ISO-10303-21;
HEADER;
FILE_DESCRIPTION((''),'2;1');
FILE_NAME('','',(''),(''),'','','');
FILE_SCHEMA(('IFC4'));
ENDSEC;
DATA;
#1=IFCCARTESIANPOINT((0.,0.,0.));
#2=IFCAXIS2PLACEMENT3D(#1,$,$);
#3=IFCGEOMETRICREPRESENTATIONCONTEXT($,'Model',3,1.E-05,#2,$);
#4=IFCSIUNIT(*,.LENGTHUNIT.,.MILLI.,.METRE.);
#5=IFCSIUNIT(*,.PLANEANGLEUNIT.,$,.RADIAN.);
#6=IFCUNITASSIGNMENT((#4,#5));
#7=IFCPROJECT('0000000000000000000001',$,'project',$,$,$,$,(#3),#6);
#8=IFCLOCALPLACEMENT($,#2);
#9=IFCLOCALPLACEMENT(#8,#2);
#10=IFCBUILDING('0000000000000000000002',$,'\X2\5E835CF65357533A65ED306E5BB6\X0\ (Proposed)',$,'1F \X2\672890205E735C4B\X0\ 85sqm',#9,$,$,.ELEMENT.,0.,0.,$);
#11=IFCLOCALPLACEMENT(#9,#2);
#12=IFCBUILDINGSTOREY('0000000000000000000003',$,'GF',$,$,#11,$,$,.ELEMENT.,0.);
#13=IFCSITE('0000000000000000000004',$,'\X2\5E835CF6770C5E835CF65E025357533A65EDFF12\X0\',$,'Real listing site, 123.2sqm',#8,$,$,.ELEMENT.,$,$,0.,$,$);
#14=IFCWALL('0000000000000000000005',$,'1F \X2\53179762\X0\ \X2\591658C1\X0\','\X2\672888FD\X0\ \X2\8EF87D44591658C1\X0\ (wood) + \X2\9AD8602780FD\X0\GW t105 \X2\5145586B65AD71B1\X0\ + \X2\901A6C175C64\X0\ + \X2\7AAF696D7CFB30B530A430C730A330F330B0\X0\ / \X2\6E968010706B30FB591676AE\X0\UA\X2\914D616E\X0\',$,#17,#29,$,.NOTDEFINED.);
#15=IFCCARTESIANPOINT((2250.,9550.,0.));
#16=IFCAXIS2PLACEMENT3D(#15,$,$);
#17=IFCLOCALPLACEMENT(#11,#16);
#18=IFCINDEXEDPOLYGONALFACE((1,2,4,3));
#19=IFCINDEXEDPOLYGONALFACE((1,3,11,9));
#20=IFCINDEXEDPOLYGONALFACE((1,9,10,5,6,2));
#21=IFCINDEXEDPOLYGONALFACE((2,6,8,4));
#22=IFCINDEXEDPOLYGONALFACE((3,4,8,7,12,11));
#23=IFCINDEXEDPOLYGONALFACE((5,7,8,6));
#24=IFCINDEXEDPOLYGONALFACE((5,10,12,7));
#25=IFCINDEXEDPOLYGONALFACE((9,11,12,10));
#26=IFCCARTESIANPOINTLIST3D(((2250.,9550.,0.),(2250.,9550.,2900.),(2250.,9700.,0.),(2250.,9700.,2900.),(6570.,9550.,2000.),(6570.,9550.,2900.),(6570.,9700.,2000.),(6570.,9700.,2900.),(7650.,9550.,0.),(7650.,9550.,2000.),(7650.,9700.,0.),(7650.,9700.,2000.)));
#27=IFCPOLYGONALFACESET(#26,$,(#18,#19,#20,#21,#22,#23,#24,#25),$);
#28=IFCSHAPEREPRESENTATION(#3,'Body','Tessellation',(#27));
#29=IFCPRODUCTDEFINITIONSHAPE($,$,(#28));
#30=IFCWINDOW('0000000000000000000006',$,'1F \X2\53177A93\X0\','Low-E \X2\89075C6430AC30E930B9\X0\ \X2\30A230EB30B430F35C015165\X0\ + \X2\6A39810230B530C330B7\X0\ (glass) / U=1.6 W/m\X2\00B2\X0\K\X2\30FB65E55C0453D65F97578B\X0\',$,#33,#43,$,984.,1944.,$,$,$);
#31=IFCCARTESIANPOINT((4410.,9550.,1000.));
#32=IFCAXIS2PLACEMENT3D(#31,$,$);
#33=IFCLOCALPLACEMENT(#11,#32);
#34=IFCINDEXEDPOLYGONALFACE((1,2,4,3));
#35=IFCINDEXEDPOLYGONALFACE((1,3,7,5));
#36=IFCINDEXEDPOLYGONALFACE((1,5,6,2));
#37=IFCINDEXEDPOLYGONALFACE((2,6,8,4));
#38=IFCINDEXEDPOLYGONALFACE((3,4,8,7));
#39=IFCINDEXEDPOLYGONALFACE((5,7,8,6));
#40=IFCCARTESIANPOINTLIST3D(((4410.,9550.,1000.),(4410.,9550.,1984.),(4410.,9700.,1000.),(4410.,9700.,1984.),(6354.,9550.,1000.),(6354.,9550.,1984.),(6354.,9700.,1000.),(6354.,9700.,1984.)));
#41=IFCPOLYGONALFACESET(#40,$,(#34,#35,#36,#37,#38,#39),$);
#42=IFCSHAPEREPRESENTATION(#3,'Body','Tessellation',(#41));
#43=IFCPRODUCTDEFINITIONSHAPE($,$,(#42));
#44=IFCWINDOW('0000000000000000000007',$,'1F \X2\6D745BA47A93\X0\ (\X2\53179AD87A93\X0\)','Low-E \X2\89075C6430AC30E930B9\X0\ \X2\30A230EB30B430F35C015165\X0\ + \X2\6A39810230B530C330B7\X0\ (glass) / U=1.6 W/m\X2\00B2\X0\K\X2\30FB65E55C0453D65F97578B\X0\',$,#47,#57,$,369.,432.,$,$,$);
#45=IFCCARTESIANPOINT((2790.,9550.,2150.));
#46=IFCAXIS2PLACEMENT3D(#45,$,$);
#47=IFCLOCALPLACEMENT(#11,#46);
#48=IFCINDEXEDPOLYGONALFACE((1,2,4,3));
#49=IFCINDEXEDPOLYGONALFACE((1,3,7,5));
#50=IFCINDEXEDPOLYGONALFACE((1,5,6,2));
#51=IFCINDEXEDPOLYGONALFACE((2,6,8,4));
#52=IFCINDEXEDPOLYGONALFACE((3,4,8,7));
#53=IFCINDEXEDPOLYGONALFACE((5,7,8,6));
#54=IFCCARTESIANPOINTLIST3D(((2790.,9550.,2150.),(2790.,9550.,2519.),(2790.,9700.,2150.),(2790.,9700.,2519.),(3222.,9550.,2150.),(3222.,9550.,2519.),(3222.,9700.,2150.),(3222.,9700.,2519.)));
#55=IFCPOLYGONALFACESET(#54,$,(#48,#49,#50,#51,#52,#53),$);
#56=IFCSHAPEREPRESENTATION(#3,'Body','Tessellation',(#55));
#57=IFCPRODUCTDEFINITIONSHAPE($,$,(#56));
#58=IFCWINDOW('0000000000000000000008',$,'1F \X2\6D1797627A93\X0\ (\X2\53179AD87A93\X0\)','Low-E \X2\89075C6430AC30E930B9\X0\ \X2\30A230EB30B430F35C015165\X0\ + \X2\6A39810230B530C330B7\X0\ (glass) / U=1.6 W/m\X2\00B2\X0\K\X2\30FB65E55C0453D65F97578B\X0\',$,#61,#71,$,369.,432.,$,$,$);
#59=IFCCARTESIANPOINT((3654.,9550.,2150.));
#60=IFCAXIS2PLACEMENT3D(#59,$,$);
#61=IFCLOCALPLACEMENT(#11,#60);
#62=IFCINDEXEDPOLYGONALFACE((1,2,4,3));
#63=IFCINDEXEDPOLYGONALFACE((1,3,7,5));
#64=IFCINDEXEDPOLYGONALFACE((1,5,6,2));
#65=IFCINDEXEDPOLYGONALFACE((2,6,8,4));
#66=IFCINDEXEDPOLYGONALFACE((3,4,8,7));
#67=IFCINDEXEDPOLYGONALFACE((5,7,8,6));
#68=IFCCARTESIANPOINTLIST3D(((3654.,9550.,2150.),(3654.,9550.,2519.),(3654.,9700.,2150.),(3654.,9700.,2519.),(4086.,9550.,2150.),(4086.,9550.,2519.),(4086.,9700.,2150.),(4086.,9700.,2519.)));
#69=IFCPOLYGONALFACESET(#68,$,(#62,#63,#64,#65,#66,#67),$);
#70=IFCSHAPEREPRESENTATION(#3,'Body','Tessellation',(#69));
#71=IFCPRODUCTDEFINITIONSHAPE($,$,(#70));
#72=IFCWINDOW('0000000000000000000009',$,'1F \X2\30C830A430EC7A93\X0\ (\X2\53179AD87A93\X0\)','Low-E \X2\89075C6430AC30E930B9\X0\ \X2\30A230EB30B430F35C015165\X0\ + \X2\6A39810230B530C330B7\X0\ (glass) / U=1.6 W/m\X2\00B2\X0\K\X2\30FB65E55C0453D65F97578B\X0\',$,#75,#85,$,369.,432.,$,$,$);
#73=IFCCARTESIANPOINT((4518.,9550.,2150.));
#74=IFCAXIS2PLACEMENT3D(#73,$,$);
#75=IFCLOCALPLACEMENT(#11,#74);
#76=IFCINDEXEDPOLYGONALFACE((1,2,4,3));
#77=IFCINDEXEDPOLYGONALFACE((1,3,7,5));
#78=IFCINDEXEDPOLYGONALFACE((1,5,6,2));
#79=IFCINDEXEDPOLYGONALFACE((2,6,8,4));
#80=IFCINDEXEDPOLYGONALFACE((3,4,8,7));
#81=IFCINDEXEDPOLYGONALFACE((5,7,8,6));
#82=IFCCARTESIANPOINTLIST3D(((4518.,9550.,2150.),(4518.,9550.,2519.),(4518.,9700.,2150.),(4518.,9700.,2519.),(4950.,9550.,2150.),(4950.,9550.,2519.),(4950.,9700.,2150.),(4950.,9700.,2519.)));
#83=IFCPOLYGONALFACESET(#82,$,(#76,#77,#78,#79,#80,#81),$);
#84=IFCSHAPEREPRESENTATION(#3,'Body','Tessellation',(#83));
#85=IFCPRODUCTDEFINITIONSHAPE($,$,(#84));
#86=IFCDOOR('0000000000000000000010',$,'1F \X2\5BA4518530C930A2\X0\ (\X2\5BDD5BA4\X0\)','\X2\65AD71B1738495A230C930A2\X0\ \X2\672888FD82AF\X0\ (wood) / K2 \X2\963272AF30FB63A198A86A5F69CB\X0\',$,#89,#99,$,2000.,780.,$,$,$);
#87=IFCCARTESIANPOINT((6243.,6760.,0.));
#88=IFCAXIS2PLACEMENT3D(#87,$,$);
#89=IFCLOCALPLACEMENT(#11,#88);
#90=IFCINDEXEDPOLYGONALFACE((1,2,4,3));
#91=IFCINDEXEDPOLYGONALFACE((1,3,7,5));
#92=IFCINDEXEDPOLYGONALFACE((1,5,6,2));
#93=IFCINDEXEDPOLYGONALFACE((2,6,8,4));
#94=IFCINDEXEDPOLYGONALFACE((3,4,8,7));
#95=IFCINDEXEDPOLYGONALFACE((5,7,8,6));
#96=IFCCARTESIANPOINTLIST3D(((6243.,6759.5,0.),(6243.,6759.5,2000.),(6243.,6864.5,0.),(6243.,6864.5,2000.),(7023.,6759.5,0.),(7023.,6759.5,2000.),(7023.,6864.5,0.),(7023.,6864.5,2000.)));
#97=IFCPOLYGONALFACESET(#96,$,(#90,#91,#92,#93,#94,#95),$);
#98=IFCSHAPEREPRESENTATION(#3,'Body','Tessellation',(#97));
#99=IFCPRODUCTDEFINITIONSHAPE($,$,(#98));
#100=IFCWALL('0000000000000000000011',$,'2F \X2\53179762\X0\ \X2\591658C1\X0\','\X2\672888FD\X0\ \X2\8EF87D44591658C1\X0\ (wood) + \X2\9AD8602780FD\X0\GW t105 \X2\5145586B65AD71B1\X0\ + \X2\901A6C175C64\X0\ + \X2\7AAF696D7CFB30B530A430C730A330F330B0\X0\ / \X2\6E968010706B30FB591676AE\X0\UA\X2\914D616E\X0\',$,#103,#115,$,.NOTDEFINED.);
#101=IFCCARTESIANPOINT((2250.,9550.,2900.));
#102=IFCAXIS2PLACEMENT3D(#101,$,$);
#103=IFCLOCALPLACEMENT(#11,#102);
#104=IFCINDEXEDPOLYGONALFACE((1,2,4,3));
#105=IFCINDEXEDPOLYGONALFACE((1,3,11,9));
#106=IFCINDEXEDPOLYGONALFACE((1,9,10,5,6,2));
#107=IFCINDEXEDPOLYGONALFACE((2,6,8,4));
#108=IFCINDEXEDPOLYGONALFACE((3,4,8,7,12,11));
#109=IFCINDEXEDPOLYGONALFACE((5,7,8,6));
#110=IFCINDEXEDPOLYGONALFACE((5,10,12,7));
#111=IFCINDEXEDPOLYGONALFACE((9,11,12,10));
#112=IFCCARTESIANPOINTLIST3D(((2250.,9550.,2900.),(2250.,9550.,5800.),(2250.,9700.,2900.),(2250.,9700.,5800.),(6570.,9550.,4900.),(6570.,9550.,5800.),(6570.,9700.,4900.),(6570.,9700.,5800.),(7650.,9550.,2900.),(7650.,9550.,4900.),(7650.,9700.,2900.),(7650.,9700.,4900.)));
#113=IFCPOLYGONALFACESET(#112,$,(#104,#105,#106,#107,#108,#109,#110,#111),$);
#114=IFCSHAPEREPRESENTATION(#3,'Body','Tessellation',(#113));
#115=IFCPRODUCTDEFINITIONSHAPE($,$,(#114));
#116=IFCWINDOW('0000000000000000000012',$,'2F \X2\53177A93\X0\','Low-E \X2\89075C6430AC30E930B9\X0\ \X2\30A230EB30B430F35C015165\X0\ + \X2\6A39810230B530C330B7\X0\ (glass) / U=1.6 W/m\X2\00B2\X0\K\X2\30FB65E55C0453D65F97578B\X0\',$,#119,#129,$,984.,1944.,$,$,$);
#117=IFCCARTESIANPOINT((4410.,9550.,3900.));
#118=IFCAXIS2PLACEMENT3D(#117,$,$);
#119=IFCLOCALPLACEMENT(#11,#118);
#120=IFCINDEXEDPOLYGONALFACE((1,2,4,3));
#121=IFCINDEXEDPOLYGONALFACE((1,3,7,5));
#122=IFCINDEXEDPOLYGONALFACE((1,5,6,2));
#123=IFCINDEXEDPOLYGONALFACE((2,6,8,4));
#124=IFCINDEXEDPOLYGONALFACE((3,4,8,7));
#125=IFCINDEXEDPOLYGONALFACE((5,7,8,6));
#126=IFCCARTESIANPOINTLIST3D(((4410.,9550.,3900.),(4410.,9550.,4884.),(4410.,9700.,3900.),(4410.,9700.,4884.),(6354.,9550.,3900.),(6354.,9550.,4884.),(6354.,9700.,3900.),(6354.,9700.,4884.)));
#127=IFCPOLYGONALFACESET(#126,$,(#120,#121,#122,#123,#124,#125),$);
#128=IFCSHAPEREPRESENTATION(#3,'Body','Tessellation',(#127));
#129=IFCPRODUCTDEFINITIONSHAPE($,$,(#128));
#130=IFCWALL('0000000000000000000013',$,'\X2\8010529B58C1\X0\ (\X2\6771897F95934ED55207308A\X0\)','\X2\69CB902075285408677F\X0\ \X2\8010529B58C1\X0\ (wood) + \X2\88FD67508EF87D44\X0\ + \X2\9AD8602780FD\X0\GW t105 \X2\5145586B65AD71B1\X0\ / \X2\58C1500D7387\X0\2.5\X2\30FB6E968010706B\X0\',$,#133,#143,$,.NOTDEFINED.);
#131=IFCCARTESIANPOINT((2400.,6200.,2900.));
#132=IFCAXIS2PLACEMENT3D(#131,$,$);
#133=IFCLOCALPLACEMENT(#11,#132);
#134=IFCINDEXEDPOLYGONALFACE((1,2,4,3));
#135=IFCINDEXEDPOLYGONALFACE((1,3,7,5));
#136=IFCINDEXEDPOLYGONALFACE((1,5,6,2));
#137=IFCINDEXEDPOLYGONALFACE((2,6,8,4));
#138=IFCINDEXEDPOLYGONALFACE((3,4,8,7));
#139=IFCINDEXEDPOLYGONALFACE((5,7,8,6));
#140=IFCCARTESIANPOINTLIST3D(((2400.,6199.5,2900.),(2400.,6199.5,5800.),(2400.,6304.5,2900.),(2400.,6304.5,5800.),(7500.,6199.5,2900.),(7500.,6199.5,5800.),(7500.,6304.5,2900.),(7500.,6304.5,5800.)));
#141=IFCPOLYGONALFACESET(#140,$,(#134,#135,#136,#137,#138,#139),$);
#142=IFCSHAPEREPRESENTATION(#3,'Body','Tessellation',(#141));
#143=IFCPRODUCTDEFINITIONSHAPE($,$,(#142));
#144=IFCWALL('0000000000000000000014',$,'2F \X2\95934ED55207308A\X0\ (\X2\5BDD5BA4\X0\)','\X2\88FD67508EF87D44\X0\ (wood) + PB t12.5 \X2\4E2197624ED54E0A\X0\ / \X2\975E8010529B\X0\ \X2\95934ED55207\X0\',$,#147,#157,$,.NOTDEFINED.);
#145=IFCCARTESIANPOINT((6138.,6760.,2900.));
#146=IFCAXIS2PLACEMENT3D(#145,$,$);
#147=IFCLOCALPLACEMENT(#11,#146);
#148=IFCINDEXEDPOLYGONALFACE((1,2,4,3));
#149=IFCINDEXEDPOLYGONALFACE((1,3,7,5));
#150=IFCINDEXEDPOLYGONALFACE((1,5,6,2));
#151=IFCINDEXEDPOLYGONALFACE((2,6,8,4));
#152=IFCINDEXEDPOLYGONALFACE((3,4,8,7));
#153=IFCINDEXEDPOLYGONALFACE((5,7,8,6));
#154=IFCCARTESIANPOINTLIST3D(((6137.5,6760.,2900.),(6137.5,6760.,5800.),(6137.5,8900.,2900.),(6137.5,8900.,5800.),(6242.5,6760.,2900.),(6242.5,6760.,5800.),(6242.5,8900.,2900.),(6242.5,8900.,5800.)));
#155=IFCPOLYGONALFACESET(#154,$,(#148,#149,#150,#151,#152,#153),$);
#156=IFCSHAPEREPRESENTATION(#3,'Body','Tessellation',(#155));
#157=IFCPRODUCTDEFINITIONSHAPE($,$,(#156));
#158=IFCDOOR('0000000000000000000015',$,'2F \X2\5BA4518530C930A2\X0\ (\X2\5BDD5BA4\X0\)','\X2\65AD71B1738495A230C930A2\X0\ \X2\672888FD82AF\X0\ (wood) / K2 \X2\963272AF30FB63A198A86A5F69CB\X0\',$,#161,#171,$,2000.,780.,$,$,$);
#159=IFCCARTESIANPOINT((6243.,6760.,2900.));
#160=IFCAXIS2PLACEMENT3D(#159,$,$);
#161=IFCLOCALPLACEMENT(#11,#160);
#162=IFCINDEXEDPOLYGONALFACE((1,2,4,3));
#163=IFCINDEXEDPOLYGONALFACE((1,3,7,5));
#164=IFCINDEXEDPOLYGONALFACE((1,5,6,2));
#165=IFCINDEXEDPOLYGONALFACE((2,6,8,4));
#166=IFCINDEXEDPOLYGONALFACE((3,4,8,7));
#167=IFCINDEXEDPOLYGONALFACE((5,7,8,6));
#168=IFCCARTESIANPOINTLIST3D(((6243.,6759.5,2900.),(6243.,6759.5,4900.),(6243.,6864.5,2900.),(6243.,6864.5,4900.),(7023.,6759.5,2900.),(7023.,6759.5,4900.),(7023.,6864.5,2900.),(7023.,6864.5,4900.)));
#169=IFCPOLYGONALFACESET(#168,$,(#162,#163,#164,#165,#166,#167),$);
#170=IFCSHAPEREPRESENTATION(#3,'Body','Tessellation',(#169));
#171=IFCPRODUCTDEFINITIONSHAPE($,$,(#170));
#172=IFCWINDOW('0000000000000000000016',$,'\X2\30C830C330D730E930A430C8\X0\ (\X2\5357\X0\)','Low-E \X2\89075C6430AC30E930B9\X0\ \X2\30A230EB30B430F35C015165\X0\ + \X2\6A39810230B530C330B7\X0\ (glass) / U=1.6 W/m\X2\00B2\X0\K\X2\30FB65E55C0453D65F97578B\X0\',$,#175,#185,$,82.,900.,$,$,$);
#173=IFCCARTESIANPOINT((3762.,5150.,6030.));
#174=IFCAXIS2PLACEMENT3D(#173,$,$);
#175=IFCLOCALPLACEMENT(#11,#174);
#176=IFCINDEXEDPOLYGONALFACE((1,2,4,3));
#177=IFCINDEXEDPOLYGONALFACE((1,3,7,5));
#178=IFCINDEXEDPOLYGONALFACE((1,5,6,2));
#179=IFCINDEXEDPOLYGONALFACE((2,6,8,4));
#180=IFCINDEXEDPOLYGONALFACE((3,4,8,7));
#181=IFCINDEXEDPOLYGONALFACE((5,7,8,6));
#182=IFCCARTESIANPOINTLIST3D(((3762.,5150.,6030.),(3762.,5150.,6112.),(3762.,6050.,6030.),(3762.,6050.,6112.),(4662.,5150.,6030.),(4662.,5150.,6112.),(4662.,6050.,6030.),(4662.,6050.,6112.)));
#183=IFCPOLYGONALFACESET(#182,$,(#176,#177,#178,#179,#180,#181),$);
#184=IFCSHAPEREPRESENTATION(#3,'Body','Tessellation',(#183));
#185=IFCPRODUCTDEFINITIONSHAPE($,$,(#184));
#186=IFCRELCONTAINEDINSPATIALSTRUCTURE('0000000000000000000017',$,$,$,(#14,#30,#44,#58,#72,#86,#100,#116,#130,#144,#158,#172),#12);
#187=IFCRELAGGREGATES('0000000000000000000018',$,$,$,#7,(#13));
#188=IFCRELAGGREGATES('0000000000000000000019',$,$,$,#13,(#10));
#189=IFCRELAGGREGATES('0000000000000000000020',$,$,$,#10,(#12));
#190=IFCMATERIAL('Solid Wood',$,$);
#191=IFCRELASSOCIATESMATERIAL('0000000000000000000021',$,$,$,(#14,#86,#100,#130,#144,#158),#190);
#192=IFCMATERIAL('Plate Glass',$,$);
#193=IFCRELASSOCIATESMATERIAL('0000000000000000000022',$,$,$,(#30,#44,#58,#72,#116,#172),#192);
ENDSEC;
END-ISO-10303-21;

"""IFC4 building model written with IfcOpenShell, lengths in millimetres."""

from ifc_helpers import new_model, si_unit, frame, frame_2d, origin, place, context, project, spatial, rectangle, extrude, material, element, fill, save


model = new_model("IFC4")

# Units and contexts
model_context = context("Model", 3, precision=1e-05, world=origin())
ifc_project = project(units=[si_unit("LENGTHUNIT", "METRE", prefix="MILLI"), si_unit("PLANEANGLEUNIT", "RADIAN")], contexts=[model_context])

# Site, building, storey
site_placement = place(None, origin())
site = spatial("IfcSite", under=ifc_project, at=site_placement, Name="広島県広島市南区旭２", ObjectType="Real listing site, 123.2sqm", CompositionType="ELEMENT", RefElevation=0.0)
building_placement = place(site_placement, origin())
building = spatial("IfcBuilding", under=site, at=building_placement, Name="広島南区旭の家 (Proposed)", ObjectType="1F 木造平屋 85sqm", CompositionType="ELEMENT", ElevationOfRefHeight=0.0, ElevationOfTerrain=0.0)
storey_placement = place(building_placement, origin())
storey = spatial("IfcBuildingStorey", under=building, at=storey_placement, Name="GF", CompositionType="ELEMENT", Elevation=0.0)

# Wall, openings, windows
ifc_material_1 = material(Name="Solid Wood")
wall_1_placement = place(storey_placement, frame((2250.0, 9550.0, 0.0)))
wall_1 = element("IfcWall", 1, at=wall_1_placement, inside=storey, material=ifc_material_1, Name="1F 北面 外壁", Description="木製 軸組外壁 (wood) + 高性能GW t105 充填断熱 + 通気層 + 窯業系サイディング / 準耐火・外皮UA配慮", PredefinedType="NOTDEFINED", context=model_context, shape_type="SweptSolid", body=[
    extrude(rectangle(XDim=5400.0, YDim=150.0, at=frame_2d((2700.0, 75.0))), frame((2250.0, 9550.0, 0.0)), (0.0, 0.0, 1.0), 2900.0),
])
opening_1_placement = place(storey_placement, frame((4410.0, 9550.0, 1000.0)))
opening_1 = element("IfcOpeningElement", 2, at=opening_1_placement, cuts=wall_1, PredefinedType="NOTDEFINED", context=model_context, shape_type="SweptSolid", body=[
    extrude(rectangle(XDim=1944.0, YDim=150.0, at=frame_2d((972.0, 75.0))), frame((4410.0, 9550.0, 1000.0)), (0.0, 0.0, 1.0), 984.0),
])
opening_2_placement = place(storey_placement, frame((2790.0, 9550.0, 2150.0)))
opening_2 = element("IfcOpeningElement", 3, at=opening_2_placement, cuts=wall_1, PredefinedType="NOTDEFINED", context=model_context, shape_type="SweptSolid", body=[
    extrude(rectangle(XDim=432.0, YDim=150.0, at=frame_2d((216.0, 75.0))), frame((2790.0, 9550.0, 2150.0)), (0.0, 0.0, 1.0), 369.0),
])
opening_3_placement = place(storey_placement, frame((3654.0, 9550.0, 2150.0)))
opening_3 = element("IfcOpeningElement", 4, at=opening_3_placement, cuts=wall_1, PredefinedType="NOTDEFINED", context=model_context, shape_type="SweptSolid", body=[
    extrude(rectangle(XDim=432.0, YDim=150.0, at=frame_2d((216.0, 75.0))), frame((3654.0, 9550.0, 2150.0)), (0.0, 0.0, 1.0), 369.0),
])
opening_4_placement = place(storey_placement, frame((4518.0, 9550.0, 2150.0)))
opening_4 = element("IfcOpeningElement", 5, at=opening_4_placement, cuts=wall_1, PredefinedType="NOTDEFINED", context=model_context, shape_type="SweptSolid", body=[
    extrude(rectangle(XDim=432.0, YDim=150.0, at=frame_2d((216.0, 75.0))), frame((4518.0, 9550.0, 2150.0)), (0.0, 0.0, 1.0), 369.0),
])
ifc_material_2 = material(Name="Plate Glass")
window_1_placement = place(storey_placement, frame((4410.0, 9550.0, 1000.0)))
window_1 = element("IfcWindow", 6, at=window_1_placement, inside=storey, material=ifc_material_2, Name="1F 北窓", Description="Low-E 複層ガラス アルゴン封入 + 樹脂サッシ (glass) / U=1.6 W/m²K・日射取得型", OverallHeight=984.0, OverallWidth=1944.0, context=model_context, shape_type="SweptSolid", body=[
    extrude(rectangle(XDim=1944.0, YDim=150.0, at=frame_2d((972.0, 75.0))), frame((4410.0, 9550.0, 1000.0)), (0.0, 0.0, 1.0), 984.0),
])
fill(opening_1, window_1)
window_2_placement = place(storey_placement, frame((2790.0, 9550.0, 2150.0)))
window_2 = element("IfcWindow", 7, at=window_2_placement, inside=storey, material=ifc_material_2, Name="1F 浴室窓 (北高窓)", Description="Low-E 複層ガラス アルゴン封入 + 樹脂サッシ (glass) / U=1.6 W/m²K・日射取得型", OverallHeight=369.0, OverallWidth=432.0, context=model_context, shape_type="SweptSolid", body=[
    extrude(rectangle(XDim=432.0, YDim=150.0, at=frame_2d((216.0, 75.0))), frame((2790.0, 9550.0, 2150.0)), (0.0, 0.0, 1.0), 369.0),
])
fill(opening_2, window_2)
window_3_placement = place(storey_placement, frame((3654.0, 9550.0, 2150.0)))
window_3 = element("IfcWindow", 8, at=window_3_placement, inside=storey, material=ifc_material_2, Name="1F 洗面窓 (北高窓)", Description="Low-E 複層ガラス アルゴン封入 + 樹脂サッシ (glass) / U=1.6 W/m²K・日射取得型", OverallHeight=369.0, OverallWidth=432.0, context=model_context, shape_type="SweptSolid", body=[
    extrude(rectangle(XDim=432.0, YDim=150.0, at=frame_2d((216.0, 75.0))), frame((3654.0, 9550.0, 2150.0)), (0.0, 0.0, 1.0), 369.0),
])
fill(opening_3, window_3)
window_4_placement = place(storey_placement, frame((4518.0, 9550.0, 2150.0)))
window_4 = element("IfcWindow", 9, at=window_4_placement, inside=storey, material=ifc_material_2, Name="1F トイレ窓 (北高窓)", Description="Low-E 複層ガラス アルゴン封入 + 樹脂サッシ (glass) / U=1.6 W/m²K・日射取得型", OverallHeight=369.0, OverallWidth=432.0, context=model_context, shape_type="SweptSolid", body=[
    extrude(rectangle(XDim=432.0, YDim=150.0, at=frame_2d((216.0, 75.0))), frame((4518.0, 9550.0, 2150.0)), (0.0, 0.0, 1.0), 369.0),
])
fill(opening_4, window_4)

# Door
door_1_placement = place(storey_placement, frame((6243.0, 6760.0, 0.0)))
element("IfcDoor", 10, at=door_1_placement, inside=storey, material=ifc_material_1, Name="1F 室内ドア (寝室)", Description="断熱玄関ドア 木製芯 (wood) / K2 防犯・採風機構", OverallHeight=2000.0, OverallWidth=780.0, context=model_context, shape_type="SweptSolid", body=[
    extrude(rectangle(XDim=780.0, YDim=105.0, at=frame_2d((390.0, 52.0))), frame((6243.0, 6760.0, 0.0)), (0.0, 0.0, 1.0), 2000.0),
])

# Wall, opening, window
wall_2_placement = place(storey_placement, frame((2250.0, 9550.0, 2900.0)))
wall_2 = element("IfcWall", 11, at=wall_2_placement, inside=storey, material=ifc_material_1, Name="2F 北面 外壁", Description="木製 軸組外壁 (wood) + 高性能GW t105 充填断熱 + 通気層 + 窯業系サイディング / 準耐火・外皮UA配慮", PredefinedType="NOTDEFINED", context=model_context, shape_type="SweptSolid", body=[
    extrude(rectangle(XDim=5400.0, YDim=150.0, at=frame_2d((2700.0, 75.0))), frame((2250.0, 9550.0, 2900.0)), (0.0, 0.0, 1.0), 2900.0),
])
opening_5_placement = place(storey_placement, frame((4410.0, 9550.0, 3900.0)))
opening_5 = element("IfcOpeningElement", 12, at=opening_5_placement, cuts=wall_2, PredefinedType="NOTDEFINED", context=model_context, shape_type="SweptSolid", body=[
    extrude(rectangle(XDim=1944.0, YDim=150.0, at=frame_2d((972.0, 75.0))), frame((4410.0, 9550.0, 3900.0)), (0.0, 0.0, 1.0), 984.0),
])
window_5_placement = place(storey_placement, frame((4410.0, 9550.0, 3900.0)))
window_5 = element("IfcWindow", 13, at=window_5_placement, inside=storey, material=ifc_material_2, Name="2F 北窓", Description="Low-E 複層ガラス アルゴン封入 + 樹脂サッシ (glass) / U=1.6 W/m²K・日射取得型", OverallHeight=984.0, OverallWidth=1944.0, context=model_context, shape_type="SweptSolid", body=[
    extrude(rectangle(XDim=1944.0, YDim=150.0, at=frame_2d((972.0, 75.0))), frame((4410.0, 9550.0, 3900.0)), (0.0, 0.0, 1.0), 984.0),
])
fill(opening_5, window_5)

# Walls
wall_3_placement = place(storey_placement, frame((2400.0, 6200.0, 2900.0)))
element("IfcWall", 14, at=wall_3_placement, inside=storey, material=ifc_material_1, Name="耐力壁 (東西間仕切り)", Description="構造用合板 耐力壁 (wood) + 製材軸組 + 高性能GW t105 充填断熱 / 壁倍率2.5・準耐火", PredefinedType="NOTDEFINED", context=model_context, shape_type="SweptSolid", body=[
    extrude(rectangle(XDim=5100.0, YDim=105.0, at=frame_2d((2550.0, 52.0))), frame((2400.0, 6200.0, 2900.0)), (0.0, 0.0, 1.0), 2900.0),
])
wall_4_placement = place(storey_placement, frame((6138.0, 6760.0, 2900.0)))
element("IfcWall", 15, at=wall_4_placement, inside=storey, material=ifc_material_1, Name="2F 間仕切り (寝室)", Description="製材軸組 (wood) + PB t12.5 両面仕上 / 非耐力 間仕切", PredefinedType="NOTDEFINED", context=model_context, shape_type="SweptSolid", body=[
    extrude(rectangle(XDim=105.0, YDim=2140.0, at=frame_2d((52.0, 1070.0))), frame((6138.0, 6760.0, 2900.0)), (0.0, 0.0, 1.0), 2900.0),
])

# Door
door_2_placement = place(storey_placement, frame((6243.0, 6760.0, 2900.0)))
element("IfcDoor", 16, at=door_2_placement, inside=storey, material=ifc_material_1, Name="2F 室内ドア (寝室)", Description="断熱玄関ドア 木製芯 (wood) / K2 防犯・採風機構", OverallHeight=2000.0, OverallWidth=780.0, context=model_context, shape_type="SweptSolid", body=[
    extrude(rectangle(XDim=780.0, YDim=105.0, at=frame_2d((390.0, 52.0))), frame((6243.0, 6760.0, 2900.0)), (0.0, 0.0, 1.0), 2000.0),
])

# Window
window_6_placement = place(storey_placement, frame((3762.0, 5150.0, 6030.0)))
element("IfcWindow", 17, at=window_6_placement, inside=storey, material=ifc_material_2, Name="トップライト (南)", Description="Low-E 複層ガラス アルゴン封入 + 樹脂サッシ (glass) / U=1.6 W/m²K・日射取得型", OverallHeight=82.0, OverallWidth=900.0, context=model_context, shape_type="SweptSolid", body=[
    extrude(rectangle(XDim=900.0, YDim=900.0, at=frame_2d((450.0, 450.0))), frame((3762.0, 5150.0, 6030.0)), (0.0, 0.0, 1.0), 82.0),
])

save(model, "model.ifc")
